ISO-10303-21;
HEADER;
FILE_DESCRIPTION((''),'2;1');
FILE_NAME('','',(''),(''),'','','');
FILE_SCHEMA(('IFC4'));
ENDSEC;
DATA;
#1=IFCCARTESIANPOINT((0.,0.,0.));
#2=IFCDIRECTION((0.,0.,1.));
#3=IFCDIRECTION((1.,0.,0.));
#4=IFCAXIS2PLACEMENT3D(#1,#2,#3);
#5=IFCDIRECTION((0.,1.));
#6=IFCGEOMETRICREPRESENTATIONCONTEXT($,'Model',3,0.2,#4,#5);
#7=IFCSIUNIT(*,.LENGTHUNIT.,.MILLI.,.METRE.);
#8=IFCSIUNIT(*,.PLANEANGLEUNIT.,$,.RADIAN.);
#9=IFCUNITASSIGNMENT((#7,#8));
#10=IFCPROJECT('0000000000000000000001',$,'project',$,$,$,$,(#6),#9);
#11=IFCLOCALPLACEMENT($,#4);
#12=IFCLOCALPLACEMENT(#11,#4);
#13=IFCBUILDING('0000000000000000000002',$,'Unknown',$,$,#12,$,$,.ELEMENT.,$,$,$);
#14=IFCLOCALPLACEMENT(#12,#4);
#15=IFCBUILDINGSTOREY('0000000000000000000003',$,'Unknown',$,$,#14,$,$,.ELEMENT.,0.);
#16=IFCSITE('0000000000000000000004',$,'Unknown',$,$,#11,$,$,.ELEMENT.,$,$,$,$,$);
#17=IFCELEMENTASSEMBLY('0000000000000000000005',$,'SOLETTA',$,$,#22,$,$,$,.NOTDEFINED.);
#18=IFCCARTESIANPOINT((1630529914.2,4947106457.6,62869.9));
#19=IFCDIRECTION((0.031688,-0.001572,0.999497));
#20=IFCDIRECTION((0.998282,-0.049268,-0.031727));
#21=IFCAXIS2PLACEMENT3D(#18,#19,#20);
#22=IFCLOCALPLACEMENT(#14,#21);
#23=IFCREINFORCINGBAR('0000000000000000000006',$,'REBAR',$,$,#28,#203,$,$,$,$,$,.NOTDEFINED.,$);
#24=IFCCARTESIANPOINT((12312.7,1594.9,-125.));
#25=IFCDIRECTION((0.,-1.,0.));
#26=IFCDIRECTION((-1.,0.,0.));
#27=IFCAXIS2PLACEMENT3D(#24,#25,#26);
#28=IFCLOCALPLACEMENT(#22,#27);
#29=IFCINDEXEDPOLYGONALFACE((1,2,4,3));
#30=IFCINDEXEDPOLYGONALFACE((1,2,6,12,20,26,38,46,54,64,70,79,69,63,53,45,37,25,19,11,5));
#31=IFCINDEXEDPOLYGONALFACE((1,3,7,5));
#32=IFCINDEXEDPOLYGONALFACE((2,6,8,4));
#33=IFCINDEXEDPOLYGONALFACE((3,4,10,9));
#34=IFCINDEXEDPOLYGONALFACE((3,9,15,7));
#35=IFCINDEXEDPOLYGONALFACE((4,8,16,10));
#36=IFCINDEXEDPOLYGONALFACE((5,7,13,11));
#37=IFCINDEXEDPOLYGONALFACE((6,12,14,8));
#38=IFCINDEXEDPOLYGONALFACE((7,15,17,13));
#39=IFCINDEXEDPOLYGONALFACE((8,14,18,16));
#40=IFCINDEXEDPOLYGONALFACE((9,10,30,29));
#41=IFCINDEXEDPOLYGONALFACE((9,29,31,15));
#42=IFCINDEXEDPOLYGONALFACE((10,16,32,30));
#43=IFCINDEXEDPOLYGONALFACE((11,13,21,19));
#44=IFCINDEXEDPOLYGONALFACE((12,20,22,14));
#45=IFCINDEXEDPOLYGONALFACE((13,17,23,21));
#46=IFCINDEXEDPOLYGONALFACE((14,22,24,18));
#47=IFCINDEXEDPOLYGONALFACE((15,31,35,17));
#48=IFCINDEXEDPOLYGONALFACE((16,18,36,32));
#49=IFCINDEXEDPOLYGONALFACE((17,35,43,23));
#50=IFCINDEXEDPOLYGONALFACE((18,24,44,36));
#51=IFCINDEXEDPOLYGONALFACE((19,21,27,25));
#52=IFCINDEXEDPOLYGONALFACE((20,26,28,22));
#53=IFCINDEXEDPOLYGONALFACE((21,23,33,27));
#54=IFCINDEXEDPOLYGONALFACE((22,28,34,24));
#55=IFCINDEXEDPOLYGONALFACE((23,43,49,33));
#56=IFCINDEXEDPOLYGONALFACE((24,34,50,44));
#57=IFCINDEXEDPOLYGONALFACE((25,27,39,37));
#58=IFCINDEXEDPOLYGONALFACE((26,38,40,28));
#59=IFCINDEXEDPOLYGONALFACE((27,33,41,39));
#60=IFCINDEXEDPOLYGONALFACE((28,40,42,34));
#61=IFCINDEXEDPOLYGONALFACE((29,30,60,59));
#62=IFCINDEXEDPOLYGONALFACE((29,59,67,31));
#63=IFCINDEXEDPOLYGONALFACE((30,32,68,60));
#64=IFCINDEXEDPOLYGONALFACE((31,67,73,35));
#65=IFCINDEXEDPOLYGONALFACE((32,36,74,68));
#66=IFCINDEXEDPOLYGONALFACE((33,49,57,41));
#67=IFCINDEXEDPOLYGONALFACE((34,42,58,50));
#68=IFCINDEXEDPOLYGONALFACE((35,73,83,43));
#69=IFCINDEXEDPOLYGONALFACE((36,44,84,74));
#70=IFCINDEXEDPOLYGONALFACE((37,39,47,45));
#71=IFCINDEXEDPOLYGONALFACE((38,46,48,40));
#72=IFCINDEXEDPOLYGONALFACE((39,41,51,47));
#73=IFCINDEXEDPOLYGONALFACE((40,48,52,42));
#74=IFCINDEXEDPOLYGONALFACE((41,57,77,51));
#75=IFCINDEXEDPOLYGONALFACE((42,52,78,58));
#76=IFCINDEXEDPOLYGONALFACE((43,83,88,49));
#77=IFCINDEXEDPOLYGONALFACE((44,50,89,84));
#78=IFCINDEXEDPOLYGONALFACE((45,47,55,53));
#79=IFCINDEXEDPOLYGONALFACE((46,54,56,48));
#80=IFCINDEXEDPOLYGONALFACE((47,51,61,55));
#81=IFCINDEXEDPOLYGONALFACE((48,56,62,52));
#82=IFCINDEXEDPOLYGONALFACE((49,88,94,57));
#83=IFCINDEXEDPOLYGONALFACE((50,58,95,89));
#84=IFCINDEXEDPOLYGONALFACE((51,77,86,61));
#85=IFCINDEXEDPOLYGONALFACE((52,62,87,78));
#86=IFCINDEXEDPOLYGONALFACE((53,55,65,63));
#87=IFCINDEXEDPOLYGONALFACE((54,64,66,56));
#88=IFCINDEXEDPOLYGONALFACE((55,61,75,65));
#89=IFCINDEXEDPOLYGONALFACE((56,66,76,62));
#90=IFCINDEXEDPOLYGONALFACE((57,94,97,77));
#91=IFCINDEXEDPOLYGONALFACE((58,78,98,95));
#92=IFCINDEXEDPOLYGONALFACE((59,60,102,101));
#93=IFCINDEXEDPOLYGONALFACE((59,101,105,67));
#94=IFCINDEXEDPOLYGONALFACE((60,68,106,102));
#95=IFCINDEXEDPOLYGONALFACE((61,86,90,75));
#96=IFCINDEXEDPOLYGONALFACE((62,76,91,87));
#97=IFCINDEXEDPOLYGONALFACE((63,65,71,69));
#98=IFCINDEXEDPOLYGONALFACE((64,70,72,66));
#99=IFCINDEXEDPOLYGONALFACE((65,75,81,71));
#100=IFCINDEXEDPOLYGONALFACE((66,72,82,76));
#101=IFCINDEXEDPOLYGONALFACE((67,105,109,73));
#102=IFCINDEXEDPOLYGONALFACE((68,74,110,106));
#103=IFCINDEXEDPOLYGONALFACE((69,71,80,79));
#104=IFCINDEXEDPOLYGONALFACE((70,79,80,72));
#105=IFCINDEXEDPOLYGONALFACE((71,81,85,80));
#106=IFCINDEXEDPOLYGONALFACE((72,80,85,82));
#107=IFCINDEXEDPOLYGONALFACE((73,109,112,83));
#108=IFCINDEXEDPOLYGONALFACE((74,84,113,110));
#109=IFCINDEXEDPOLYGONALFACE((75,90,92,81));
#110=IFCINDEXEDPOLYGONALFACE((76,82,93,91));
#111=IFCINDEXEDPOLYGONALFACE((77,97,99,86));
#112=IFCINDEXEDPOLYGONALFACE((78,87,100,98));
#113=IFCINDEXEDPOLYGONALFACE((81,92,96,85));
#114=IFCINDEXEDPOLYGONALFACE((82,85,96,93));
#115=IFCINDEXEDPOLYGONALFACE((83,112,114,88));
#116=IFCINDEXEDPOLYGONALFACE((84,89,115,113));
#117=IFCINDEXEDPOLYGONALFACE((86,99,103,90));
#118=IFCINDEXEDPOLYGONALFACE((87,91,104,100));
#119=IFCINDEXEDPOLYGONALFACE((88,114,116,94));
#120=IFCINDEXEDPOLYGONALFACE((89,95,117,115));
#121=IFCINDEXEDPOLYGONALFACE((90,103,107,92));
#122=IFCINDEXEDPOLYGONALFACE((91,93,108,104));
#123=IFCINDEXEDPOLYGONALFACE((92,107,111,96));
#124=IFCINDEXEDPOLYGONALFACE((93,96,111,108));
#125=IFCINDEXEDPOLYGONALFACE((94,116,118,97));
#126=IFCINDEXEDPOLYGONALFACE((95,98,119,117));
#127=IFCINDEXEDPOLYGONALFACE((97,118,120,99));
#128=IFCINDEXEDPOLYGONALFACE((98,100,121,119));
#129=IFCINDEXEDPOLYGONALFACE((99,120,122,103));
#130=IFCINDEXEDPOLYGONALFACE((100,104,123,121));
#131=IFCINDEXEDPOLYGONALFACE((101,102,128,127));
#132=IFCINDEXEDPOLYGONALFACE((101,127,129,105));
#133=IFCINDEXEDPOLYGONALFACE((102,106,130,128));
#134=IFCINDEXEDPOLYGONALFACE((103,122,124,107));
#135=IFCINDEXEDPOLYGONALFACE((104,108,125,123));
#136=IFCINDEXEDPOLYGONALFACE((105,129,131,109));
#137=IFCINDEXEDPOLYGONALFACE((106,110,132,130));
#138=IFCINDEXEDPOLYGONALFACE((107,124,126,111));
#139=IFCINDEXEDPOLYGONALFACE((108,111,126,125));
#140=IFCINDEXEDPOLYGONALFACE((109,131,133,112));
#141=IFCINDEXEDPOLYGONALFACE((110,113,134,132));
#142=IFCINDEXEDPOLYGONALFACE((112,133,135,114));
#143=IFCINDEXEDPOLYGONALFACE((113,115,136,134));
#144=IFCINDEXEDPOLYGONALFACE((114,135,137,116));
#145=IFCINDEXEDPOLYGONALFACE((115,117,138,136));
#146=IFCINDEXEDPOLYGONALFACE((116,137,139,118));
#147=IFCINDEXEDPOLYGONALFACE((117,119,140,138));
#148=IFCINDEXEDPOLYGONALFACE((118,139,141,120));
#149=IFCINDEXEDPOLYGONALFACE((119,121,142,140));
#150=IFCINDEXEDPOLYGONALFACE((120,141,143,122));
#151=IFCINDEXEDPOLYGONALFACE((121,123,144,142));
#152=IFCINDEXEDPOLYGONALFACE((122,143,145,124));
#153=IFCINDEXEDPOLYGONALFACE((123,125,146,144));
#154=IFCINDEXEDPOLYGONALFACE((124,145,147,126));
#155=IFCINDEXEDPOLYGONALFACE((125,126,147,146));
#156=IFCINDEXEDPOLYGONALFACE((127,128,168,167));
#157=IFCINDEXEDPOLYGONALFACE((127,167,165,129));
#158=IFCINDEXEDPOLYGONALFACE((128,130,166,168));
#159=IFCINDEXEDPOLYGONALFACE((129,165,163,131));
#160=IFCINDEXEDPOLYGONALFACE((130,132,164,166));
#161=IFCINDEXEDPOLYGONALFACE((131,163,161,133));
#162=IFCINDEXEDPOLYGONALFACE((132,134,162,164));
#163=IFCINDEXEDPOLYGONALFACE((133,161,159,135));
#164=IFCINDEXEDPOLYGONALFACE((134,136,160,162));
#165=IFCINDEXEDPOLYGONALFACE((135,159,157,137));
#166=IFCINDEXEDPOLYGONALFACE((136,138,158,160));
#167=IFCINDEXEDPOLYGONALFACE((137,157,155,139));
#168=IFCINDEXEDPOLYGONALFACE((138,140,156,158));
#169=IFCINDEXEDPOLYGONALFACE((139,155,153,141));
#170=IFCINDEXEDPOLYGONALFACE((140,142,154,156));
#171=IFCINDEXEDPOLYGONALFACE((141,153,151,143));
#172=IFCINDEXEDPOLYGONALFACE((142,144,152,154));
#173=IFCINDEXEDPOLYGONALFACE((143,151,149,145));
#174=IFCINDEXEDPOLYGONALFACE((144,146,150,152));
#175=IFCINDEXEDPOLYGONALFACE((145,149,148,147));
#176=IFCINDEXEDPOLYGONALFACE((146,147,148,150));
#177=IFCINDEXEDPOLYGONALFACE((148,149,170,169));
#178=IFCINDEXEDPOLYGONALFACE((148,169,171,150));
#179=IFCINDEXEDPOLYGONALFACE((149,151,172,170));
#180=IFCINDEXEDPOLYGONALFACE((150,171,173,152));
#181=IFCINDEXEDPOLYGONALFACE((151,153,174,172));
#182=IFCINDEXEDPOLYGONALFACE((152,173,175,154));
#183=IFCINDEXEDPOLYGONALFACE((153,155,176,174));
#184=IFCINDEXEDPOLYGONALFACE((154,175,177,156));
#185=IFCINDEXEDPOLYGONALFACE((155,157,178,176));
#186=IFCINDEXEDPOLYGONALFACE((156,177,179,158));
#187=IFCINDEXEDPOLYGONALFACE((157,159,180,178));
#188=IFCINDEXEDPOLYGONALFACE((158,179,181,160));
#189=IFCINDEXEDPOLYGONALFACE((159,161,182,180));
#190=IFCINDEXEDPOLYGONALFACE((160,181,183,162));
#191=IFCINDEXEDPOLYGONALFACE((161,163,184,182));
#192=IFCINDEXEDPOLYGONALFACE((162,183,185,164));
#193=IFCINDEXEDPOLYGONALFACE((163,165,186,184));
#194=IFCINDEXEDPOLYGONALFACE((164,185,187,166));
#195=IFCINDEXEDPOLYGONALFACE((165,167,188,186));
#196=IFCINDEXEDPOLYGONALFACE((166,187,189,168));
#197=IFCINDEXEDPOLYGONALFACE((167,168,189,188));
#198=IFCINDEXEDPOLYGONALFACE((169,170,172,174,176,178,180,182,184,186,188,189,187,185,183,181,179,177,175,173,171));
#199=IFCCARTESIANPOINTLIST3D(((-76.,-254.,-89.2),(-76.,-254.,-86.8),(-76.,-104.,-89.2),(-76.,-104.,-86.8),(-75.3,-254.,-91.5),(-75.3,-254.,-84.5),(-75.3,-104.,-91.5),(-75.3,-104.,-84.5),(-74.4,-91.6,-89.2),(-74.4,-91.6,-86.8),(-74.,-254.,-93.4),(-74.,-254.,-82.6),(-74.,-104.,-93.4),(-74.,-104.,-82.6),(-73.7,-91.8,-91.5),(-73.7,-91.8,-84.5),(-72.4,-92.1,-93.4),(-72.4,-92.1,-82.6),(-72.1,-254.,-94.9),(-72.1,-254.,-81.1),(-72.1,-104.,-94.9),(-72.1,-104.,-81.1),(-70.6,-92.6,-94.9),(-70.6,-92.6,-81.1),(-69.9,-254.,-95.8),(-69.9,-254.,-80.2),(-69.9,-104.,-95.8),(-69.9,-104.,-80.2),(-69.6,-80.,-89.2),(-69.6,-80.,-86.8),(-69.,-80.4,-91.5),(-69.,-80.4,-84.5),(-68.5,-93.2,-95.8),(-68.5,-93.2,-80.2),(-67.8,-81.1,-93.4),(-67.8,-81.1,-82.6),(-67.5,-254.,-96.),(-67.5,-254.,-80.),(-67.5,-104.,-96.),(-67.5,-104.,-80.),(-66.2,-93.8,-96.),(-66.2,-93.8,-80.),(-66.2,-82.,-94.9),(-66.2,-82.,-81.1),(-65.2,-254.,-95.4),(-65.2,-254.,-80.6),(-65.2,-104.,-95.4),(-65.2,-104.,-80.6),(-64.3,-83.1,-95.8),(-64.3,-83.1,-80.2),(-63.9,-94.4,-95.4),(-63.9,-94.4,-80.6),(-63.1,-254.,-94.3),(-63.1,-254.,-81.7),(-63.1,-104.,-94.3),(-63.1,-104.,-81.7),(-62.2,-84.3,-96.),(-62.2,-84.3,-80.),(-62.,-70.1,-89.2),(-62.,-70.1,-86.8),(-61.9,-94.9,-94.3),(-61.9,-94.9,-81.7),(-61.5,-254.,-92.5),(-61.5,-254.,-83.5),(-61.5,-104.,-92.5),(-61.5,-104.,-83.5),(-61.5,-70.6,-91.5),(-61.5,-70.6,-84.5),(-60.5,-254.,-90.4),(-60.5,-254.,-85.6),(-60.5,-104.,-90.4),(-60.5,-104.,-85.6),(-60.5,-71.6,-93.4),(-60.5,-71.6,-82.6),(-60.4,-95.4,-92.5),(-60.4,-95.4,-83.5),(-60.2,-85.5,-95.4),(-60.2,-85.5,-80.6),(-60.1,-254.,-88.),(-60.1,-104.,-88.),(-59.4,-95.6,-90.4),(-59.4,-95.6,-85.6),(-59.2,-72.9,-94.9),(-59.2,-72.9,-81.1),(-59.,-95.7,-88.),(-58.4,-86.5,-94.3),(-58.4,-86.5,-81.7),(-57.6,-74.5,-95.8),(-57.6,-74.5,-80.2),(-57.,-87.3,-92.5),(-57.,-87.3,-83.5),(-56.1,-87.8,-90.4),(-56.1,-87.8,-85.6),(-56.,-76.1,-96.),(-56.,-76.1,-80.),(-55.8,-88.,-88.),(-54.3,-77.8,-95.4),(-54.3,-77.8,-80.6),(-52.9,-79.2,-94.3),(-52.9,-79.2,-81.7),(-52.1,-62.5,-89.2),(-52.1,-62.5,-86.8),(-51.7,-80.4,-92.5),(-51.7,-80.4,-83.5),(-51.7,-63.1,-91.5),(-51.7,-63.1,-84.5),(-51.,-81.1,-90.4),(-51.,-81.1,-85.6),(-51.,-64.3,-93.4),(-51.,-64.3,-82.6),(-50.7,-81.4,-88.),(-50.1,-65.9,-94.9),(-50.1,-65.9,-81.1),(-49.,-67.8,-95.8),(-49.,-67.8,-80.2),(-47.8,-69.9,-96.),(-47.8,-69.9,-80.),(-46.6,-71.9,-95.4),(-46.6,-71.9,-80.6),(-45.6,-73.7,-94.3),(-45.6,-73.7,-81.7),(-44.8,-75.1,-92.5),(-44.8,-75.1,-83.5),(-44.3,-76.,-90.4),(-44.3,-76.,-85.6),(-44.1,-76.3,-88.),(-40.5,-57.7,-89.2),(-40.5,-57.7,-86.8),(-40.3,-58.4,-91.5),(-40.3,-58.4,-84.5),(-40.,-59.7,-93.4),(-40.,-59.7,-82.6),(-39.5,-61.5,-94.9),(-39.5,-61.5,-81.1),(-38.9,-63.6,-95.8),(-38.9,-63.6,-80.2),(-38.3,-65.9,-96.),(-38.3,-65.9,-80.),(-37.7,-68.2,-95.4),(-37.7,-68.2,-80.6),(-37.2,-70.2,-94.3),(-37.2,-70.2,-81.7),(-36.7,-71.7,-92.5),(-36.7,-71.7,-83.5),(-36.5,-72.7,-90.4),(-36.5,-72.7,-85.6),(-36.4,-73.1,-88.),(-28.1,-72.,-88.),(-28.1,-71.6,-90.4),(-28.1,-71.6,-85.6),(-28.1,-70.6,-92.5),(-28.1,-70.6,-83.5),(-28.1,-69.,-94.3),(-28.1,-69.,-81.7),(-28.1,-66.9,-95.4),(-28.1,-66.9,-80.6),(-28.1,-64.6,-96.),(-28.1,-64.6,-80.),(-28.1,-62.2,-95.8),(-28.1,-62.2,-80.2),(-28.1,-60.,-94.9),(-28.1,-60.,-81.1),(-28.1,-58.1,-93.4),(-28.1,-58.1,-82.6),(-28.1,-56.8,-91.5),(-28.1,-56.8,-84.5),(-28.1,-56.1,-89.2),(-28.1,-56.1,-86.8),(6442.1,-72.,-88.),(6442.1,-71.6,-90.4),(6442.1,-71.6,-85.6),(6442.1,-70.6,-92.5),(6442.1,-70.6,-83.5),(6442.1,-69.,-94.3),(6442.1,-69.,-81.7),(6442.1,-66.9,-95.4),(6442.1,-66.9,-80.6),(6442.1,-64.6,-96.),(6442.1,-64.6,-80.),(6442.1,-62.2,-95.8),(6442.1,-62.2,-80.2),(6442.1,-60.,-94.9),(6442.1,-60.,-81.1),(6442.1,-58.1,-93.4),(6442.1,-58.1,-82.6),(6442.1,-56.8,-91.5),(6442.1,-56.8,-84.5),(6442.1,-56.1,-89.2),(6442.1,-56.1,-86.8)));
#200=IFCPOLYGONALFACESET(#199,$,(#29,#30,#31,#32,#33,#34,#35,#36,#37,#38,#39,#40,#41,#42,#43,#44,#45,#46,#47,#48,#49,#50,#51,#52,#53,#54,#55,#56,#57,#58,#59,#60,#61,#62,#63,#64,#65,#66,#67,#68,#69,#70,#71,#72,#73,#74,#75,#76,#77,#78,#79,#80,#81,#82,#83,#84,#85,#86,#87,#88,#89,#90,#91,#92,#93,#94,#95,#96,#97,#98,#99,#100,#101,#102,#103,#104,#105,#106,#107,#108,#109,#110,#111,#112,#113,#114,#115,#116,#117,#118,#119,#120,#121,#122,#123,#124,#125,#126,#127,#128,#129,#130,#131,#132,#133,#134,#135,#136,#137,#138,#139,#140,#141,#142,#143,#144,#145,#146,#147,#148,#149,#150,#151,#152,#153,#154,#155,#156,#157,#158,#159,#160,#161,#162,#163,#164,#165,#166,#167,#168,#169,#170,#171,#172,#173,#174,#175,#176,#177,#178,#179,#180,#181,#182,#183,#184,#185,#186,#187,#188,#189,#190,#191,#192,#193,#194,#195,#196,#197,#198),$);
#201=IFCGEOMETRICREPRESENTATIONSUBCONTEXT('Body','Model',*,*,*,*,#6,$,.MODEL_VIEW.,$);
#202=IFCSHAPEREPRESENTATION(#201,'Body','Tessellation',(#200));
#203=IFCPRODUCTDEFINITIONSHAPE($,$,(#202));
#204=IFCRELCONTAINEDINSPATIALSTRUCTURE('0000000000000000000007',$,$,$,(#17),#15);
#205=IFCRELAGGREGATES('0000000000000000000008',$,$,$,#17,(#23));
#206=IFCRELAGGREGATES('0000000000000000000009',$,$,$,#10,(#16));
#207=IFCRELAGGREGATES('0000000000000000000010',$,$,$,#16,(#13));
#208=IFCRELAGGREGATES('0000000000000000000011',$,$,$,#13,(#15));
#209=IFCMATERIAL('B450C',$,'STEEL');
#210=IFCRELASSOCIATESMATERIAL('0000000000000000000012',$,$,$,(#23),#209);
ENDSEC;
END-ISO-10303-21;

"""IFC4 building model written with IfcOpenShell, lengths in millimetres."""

from ifc_helpers import new_model, entity, si_unit, direction, frame, origin_with_axes, place, context, subcontext, project, spatial, material, element, aggregate, save


model = new_model("IFC4")

# Units and contexts
model_context = context("Model", 3, precision=0.2, world=origin_with_axes(), true_north=direction((0.0, 1.0)))
body_context = subcontext(model_context, "Body", "Model", "MODEL_VIEW")
ifc_project = project(units=[si_unit("LENGTHUNIT", "METRE", prefix="MILLI"), si_unit("PLANEANGLEUNIT", "RADIAN")], contexts=[model_context])

# Site, building, storey
site_placement = place(None, origin_with_axes())
site = spatial("IfcSite", under=ifc_project, at=site_placement, Name="Unknown", CompositionType="ELEMENT")
building_placement = place(site_placement, origin_with_axes())
building = spatial("IfcBuilding", under=site, at=building_placement, Name="Unknown", CompositionType="ELEMENT")
storey_placement = place(building_placement, origin_with_axes())
storey = spatial("IfcBuildingStorey", under=building, at=storey_placement, Name="Unknown", CompositionType="ELEMENT", Elevation=0.0)

# Shared definitions
ifc_material = material(Name="B450C", Category="STEEL")

# Element assembly, reinforcing bar
assembly_1_placement = place(storey_placement, frame((1630529914.2, 4947106457.6, 62869.9), z_axis=(0.031688, -0.001572, 0.999497), x_axis=(0.998282, -0.049268, -0.031727)))
assembly_1 = element("IfcElementAssembly", 1, at=assembly_1_placement, inside=storey, Name="SOLETTA", PredefinedType="NOTDEFINED")
reinforcing_bar_1_placement = place(assembly_1_placement, frame((12312.7, 1594.9, -125.0), z_axis=(0.0, -1.0, 0.0), x_axis=(-1.0, 0.0, 0.0)))
reinforcing_bar_1 = element("IfcReinforcingBar", 2, at=reinforcing_bar_1_placement, material=ifc_material, Name="REBAR", PredefinedType="NOTDEFINED", context=body_context, shape_type="AdvancedSweptSolid", body=[
    entity("IfcSweptDiskSolid", entity("IfcIndexedPolyCurve", entity("IfcCartesianPointList3D", [[-68.1, -254.0, -88.0], [-68.1, -104.0, -88.0], [-56.4, -75.7, -88.0], [-28.1, -64.0, -88.0], [6442.1, -64.0, -88.0]]), [entity("IfcLineIndex", [1, 2]), entity("IfcArcIndex", [2, 3, 4]), entity("IfcLineIndex", [4, 5])]), 8.0),
])
aggregate(assembly_1, [reinforcing_bar_1])

save(model, "model.ifc")
